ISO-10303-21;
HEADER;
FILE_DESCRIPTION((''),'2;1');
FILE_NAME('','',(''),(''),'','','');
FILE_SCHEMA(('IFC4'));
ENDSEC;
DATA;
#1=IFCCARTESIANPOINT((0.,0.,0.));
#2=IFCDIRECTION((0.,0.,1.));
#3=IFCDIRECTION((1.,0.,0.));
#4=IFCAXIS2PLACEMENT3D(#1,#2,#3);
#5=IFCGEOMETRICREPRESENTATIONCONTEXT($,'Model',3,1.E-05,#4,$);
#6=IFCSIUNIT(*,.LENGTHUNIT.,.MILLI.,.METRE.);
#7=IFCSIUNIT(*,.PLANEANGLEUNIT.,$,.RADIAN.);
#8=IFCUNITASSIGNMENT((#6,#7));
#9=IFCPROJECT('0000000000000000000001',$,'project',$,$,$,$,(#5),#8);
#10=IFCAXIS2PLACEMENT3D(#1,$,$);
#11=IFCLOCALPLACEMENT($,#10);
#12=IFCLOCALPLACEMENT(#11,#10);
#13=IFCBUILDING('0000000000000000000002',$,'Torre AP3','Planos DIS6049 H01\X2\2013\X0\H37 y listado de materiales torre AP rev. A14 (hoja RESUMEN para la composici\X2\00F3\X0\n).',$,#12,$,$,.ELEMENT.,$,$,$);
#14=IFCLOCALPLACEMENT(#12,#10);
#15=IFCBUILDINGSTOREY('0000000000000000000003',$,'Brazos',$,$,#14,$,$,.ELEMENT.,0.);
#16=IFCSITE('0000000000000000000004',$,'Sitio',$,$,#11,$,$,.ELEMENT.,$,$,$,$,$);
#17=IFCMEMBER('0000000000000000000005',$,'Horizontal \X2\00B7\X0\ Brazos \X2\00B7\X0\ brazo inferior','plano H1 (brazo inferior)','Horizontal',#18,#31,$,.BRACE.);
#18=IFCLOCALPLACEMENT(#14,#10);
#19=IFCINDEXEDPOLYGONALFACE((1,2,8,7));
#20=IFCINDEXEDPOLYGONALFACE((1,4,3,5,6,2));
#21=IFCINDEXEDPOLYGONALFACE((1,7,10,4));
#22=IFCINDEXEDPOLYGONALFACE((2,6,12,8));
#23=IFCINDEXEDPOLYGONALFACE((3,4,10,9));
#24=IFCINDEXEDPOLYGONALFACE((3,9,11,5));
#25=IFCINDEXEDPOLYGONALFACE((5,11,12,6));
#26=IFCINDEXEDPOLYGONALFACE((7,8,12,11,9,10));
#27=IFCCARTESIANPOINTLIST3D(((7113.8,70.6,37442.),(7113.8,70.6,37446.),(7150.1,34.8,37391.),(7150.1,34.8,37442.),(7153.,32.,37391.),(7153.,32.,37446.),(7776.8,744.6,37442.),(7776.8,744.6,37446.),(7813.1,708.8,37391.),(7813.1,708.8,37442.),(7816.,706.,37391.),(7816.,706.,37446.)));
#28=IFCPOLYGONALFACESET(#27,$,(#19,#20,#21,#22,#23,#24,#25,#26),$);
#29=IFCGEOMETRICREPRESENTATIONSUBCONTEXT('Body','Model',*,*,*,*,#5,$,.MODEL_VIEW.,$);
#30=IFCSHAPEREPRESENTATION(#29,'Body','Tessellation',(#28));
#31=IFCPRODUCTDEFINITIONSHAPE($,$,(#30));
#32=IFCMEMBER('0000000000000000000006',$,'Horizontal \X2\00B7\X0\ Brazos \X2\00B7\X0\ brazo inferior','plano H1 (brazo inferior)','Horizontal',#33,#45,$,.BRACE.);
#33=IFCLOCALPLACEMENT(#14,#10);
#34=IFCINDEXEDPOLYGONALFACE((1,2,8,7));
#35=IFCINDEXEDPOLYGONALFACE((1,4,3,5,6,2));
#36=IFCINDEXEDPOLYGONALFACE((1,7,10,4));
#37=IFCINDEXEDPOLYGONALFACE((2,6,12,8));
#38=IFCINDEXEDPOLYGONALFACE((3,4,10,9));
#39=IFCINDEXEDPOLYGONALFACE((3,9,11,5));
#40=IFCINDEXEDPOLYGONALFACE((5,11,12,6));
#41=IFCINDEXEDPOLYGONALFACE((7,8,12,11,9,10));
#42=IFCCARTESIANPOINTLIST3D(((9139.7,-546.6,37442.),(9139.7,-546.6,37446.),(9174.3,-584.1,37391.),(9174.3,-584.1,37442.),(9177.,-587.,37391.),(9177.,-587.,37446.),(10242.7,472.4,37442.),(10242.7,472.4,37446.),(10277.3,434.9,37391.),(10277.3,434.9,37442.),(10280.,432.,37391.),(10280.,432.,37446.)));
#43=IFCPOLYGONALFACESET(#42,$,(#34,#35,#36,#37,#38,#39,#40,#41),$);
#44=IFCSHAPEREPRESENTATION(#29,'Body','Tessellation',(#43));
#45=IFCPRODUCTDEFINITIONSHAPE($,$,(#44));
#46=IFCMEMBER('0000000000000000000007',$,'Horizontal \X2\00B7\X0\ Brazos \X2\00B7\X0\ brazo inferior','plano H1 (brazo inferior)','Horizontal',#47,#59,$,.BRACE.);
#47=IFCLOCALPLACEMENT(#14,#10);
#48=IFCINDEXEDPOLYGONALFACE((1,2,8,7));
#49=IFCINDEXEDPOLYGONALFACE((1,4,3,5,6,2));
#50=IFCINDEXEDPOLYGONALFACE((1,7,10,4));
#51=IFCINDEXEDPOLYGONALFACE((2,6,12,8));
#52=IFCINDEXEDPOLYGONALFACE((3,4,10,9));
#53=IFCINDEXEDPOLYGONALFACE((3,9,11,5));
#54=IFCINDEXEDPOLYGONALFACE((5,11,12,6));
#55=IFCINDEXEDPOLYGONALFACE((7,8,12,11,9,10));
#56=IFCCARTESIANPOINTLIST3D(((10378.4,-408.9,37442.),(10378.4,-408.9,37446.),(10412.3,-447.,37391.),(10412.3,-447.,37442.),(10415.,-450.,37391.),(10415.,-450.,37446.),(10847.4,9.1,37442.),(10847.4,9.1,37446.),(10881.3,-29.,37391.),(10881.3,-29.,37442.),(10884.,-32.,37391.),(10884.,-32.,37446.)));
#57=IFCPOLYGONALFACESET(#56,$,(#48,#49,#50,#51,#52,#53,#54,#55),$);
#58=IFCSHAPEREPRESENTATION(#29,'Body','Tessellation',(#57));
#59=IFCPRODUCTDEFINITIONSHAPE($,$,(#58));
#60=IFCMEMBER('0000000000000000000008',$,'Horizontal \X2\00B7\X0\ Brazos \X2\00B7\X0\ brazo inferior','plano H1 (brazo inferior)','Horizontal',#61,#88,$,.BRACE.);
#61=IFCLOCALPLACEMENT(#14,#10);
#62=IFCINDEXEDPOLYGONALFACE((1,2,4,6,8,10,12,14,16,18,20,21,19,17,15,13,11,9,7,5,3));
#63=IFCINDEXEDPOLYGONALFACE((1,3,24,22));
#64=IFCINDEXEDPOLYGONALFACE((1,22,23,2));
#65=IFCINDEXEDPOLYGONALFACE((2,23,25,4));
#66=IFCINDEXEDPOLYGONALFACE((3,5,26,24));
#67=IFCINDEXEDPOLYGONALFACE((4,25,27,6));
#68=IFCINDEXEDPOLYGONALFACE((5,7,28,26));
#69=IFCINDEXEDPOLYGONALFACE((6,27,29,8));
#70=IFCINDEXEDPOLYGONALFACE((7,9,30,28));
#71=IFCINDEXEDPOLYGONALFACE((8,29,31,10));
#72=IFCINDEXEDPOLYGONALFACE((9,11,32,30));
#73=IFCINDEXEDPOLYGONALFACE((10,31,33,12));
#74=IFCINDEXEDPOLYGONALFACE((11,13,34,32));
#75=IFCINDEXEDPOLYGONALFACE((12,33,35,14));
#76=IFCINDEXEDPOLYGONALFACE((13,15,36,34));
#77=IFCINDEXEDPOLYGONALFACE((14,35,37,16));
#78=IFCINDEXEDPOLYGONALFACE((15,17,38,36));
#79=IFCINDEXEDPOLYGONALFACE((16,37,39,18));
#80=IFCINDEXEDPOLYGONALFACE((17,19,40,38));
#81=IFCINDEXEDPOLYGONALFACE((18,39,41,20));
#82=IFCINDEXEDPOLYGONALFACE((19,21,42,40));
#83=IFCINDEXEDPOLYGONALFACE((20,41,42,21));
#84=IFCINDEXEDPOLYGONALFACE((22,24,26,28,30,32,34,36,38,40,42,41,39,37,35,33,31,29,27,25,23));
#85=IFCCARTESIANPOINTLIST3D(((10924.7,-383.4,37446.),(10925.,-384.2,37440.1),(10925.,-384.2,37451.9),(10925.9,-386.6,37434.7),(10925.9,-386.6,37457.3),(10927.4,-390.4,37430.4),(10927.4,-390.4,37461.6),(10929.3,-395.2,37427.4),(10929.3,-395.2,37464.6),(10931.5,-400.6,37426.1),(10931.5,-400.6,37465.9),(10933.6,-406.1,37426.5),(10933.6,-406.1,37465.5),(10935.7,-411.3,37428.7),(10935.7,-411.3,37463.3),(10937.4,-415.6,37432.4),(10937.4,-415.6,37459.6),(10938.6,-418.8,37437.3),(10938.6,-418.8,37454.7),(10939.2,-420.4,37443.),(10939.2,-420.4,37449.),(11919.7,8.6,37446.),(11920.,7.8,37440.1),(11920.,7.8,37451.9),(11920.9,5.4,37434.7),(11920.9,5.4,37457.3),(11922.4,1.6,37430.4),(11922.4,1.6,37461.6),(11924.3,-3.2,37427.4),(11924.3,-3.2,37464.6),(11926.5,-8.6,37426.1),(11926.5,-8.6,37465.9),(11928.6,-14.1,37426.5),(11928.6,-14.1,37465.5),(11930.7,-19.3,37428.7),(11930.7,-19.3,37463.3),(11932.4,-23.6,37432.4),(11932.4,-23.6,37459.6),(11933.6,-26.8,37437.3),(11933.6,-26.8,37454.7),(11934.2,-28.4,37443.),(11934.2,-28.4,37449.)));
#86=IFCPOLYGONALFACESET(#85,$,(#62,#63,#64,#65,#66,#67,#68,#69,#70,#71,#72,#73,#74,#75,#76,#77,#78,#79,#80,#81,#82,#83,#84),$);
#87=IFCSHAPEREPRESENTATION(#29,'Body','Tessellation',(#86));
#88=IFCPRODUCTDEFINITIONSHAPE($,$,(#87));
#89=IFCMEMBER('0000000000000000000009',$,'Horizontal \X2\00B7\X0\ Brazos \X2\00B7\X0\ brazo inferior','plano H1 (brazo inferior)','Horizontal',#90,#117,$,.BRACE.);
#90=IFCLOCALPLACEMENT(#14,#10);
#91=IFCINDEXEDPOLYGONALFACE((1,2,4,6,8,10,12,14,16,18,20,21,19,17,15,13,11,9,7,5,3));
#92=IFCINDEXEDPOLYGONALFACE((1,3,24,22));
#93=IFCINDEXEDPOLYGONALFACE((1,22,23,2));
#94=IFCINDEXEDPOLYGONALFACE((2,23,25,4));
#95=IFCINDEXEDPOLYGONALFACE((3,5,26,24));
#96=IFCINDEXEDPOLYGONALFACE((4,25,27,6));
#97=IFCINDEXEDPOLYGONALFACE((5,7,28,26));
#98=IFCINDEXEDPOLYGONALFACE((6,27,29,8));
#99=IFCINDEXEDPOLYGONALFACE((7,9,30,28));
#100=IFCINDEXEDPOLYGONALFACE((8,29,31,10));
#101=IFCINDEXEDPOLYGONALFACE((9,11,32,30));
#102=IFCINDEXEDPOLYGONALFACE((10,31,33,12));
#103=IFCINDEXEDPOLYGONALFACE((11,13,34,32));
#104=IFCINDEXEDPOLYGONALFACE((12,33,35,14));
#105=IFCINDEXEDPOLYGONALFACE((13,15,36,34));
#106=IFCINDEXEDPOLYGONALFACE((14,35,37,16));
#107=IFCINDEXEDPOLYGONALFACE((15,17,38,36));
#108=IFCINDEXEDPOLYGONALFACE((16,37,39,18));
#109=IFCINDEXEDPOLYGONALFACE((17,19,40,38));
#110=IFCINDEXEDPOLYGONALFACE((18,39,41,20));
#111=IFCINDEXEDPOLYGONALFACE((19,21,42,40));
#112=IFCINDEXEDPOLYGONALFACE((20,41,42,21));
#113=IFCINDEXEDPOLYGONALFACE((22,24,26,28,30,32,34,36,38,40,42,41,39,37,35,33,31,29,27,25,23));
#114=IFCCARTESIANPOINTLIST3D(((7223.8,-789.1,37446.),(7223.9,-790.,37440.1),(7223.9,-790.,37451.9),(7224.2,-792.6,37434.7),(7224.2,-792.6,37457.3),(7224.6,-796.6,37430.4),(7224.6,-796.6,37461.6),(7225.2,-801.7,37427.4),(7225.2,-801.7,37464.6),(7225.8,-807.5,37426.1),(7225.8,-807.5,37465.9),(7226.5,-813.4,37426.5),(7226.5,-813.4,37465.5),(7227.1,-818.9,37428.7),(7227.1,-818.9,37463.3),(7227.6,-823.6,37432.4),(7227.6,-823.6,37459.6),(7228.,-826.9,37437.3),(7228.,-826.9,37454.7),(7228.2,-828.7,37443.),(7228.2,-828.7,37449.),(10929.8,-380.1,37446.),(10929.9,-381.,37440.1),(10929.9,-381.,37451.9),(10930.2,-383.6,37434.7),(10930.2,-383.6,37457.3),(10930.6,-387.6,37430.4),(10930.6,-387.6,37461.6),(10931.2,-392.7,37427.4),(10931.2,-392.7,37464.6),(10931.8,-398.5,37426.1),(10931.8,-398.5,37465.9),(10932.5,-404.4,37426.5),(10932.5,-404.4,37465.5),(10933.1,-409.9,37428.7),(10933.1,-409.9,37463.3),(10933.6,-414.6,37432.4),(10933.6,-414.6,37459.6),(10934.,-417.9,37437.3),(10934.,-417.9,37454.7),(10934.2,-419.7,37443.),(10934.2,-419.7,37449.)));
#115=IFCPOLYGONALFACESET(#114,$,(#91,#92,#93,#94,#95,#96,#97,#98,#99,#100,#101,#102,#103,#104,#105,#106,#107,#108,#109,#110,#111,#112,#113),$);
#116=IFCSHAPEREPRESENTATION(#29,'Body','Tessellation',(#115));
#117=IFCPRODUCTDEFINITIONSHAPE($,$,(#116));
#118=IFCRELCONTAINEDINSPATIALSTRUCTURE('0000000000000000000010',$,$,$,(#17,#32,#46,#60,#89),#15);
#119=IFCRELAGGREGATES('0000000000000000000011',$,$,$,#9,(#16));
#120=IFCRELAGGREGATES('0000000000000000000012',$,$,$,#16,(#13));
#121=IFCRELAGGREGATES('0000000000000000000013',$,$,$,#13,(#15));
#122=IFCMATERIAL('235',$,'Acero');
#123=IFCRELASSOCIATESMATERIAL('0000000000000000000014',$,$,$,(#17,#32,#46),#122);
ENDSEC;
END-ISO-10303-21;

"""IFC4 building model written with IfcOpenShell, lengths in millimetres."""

from ifc_helpers import new_model, si_unit, frame, frame_2d, origin, origin_with_axes, place, context, subcontext, project, spatial, circle, l_section, extrude, material, element, save


model = new_model("IFC4")

# Units and contexts
model_context = context("Model", 3, precision=1e-05, world=origin_with_axes())
body_context = subcontext(model_context, "Body", "Model", "MODEL_VIEW")
ifc_project = project(units=[si_unit("LENGTHUNIT", "METRE", prefix="MILLI"), si_unit("PLANEANGLEUNIT", "RADIAN")], contexts=[model_context])

# Site, building, storey
site_placement = place(None, origin())
site = spatial("IfcSite", under=ifc_project, at=site_placement, Name="Sitio", CompositionType="ELEMENT")
building_placement = place(site_placement, origin())
building = spatial("IfcBuilding", under=site, at=building_placement, Name="Torre AP3", Description="Planos DIS6049 H01–H37 y listado de materiales torre AP rev. A14 (hoja RESUMEN para la composición).", CompositionType="ELEMENT")
storey_placement = place(building_placement, origin())
storey = spatial("IfcBuildingStorey", under=building, at=storey_placement, Name="Brazos", CompositionType="ELEMENT", Elevation=0.0)

# Members
ifc_material_1 = material(Name="235", Category="Acero")
member_1_placement = place(storey_placement, frame((7816.0, 706.0, 37446.0), z_axis=(-0.701265, -0.7129, 0.0), x_axis=(-0.7129, 0.701265, 0.0)))
element("IfcMember", 1, at=member_1_placement, inside=storey, material=ifc_material_1, Name="Horizontal · Brazos · brazo inferior", Description="plano H1 (brazo inferior)", ObjectType="Horizontal", PredefinedType="BRACE", context=body_context, shape_type="SweptSolid", body=[
    extrude(l_section(Depth=55.0, Width=55.0, Thickness=4.0, at=frame_2d((27.5, 27.5))), None, (0.0, 0.0, 1.0), 945.4),
])
member_2_placement = place(storey_placement, frame((10280.0, 432.0, 37446.0), z_axis=(-0.734523, -0.678584, 0.0), x_axis=(-0.678584, 0.734523, 0.0)))
element("IfcMember", 2, at=member_2_placement, inside=storey, material=ifc_material_1, Name="Horizontal · Brazos · brazo inferior", Description="plano H1 (brazo inferior)", ObjectType="Horizontal", PredefinedType="BRACE", context=body_context, shape_type="SweptSolid", body=[
    extrude(l_section(Depth=55.0, Width=55.0, Thickness=4.0, at=frame_2d((27.5, 27.5))), None, (0.0, 0.0, 1.0), 1501.7),
])
member_3_placement = place(storey_placement, frame((10884.0, -32.0, 37446.0), z_axis=(-0.74653, -0.665351, 0.0), x_axis=(-0.665351, 0.74653, 0.0)))
element("IfcMember", 3, at=member_3_placement, inside=storey, material=ifc_material_1, Name="Horizontal · Brazos · brazo inferior", Description="plano H1 (brazo inferior)", ObjectType="Horizontal", PredefinedType="BRACE", context=body_context, shape_type="SweptSolid", body=[
    extrude(l_section(Depth=55.0, Width=55.0, Thickness=4.0, at=frame_2d((27.5, 27.5))), None, (0.0, 0.0, 1.0), 628.2),
])
member_4_placement = place(storey_placement, frame((11927.0, -10.0, 37446.0), z_axis=(-0.930399, -0.366549, 0.0), x_axis=(-0.366549, 0.930399, 0.0)))
element("IfcMember", 4, at=member_4_placement, inside=storey, Name="Horizontal · Brazos · brazo inferior", Description="plano H1 (brazo inferior)", ObjectType="Horizontal", PredefinedType="BRACE", context=body_context, shape_type="SweptSolid", body=[
    extrude(circle(Radius=20.0), None, (0.0, 0.0, 1.0), 1069.4),
])
member_5_placement = place(storey_placement, frame((10932.0, -400.0, 37446.0), z_axis=(-0.993965, -0.109696, 0.0), x_axis=(-0.109696, 0.993965, 0.0)))
element("IfcMember", 5, at=member_5_placement, inside=storey, Name="Horizontal · Brazos · brazo inferior", Description="plano H1 (brazo inferior)", ObjectType="Horizontal", PredefinedType="BRACE", context=body_context, shape_type="SweptSolid", body=[
    extrude(circle(Radius=20.0), None, (0.0, 0.0, 1.0), 3728.5),
])

save(model, "model.ifc")
